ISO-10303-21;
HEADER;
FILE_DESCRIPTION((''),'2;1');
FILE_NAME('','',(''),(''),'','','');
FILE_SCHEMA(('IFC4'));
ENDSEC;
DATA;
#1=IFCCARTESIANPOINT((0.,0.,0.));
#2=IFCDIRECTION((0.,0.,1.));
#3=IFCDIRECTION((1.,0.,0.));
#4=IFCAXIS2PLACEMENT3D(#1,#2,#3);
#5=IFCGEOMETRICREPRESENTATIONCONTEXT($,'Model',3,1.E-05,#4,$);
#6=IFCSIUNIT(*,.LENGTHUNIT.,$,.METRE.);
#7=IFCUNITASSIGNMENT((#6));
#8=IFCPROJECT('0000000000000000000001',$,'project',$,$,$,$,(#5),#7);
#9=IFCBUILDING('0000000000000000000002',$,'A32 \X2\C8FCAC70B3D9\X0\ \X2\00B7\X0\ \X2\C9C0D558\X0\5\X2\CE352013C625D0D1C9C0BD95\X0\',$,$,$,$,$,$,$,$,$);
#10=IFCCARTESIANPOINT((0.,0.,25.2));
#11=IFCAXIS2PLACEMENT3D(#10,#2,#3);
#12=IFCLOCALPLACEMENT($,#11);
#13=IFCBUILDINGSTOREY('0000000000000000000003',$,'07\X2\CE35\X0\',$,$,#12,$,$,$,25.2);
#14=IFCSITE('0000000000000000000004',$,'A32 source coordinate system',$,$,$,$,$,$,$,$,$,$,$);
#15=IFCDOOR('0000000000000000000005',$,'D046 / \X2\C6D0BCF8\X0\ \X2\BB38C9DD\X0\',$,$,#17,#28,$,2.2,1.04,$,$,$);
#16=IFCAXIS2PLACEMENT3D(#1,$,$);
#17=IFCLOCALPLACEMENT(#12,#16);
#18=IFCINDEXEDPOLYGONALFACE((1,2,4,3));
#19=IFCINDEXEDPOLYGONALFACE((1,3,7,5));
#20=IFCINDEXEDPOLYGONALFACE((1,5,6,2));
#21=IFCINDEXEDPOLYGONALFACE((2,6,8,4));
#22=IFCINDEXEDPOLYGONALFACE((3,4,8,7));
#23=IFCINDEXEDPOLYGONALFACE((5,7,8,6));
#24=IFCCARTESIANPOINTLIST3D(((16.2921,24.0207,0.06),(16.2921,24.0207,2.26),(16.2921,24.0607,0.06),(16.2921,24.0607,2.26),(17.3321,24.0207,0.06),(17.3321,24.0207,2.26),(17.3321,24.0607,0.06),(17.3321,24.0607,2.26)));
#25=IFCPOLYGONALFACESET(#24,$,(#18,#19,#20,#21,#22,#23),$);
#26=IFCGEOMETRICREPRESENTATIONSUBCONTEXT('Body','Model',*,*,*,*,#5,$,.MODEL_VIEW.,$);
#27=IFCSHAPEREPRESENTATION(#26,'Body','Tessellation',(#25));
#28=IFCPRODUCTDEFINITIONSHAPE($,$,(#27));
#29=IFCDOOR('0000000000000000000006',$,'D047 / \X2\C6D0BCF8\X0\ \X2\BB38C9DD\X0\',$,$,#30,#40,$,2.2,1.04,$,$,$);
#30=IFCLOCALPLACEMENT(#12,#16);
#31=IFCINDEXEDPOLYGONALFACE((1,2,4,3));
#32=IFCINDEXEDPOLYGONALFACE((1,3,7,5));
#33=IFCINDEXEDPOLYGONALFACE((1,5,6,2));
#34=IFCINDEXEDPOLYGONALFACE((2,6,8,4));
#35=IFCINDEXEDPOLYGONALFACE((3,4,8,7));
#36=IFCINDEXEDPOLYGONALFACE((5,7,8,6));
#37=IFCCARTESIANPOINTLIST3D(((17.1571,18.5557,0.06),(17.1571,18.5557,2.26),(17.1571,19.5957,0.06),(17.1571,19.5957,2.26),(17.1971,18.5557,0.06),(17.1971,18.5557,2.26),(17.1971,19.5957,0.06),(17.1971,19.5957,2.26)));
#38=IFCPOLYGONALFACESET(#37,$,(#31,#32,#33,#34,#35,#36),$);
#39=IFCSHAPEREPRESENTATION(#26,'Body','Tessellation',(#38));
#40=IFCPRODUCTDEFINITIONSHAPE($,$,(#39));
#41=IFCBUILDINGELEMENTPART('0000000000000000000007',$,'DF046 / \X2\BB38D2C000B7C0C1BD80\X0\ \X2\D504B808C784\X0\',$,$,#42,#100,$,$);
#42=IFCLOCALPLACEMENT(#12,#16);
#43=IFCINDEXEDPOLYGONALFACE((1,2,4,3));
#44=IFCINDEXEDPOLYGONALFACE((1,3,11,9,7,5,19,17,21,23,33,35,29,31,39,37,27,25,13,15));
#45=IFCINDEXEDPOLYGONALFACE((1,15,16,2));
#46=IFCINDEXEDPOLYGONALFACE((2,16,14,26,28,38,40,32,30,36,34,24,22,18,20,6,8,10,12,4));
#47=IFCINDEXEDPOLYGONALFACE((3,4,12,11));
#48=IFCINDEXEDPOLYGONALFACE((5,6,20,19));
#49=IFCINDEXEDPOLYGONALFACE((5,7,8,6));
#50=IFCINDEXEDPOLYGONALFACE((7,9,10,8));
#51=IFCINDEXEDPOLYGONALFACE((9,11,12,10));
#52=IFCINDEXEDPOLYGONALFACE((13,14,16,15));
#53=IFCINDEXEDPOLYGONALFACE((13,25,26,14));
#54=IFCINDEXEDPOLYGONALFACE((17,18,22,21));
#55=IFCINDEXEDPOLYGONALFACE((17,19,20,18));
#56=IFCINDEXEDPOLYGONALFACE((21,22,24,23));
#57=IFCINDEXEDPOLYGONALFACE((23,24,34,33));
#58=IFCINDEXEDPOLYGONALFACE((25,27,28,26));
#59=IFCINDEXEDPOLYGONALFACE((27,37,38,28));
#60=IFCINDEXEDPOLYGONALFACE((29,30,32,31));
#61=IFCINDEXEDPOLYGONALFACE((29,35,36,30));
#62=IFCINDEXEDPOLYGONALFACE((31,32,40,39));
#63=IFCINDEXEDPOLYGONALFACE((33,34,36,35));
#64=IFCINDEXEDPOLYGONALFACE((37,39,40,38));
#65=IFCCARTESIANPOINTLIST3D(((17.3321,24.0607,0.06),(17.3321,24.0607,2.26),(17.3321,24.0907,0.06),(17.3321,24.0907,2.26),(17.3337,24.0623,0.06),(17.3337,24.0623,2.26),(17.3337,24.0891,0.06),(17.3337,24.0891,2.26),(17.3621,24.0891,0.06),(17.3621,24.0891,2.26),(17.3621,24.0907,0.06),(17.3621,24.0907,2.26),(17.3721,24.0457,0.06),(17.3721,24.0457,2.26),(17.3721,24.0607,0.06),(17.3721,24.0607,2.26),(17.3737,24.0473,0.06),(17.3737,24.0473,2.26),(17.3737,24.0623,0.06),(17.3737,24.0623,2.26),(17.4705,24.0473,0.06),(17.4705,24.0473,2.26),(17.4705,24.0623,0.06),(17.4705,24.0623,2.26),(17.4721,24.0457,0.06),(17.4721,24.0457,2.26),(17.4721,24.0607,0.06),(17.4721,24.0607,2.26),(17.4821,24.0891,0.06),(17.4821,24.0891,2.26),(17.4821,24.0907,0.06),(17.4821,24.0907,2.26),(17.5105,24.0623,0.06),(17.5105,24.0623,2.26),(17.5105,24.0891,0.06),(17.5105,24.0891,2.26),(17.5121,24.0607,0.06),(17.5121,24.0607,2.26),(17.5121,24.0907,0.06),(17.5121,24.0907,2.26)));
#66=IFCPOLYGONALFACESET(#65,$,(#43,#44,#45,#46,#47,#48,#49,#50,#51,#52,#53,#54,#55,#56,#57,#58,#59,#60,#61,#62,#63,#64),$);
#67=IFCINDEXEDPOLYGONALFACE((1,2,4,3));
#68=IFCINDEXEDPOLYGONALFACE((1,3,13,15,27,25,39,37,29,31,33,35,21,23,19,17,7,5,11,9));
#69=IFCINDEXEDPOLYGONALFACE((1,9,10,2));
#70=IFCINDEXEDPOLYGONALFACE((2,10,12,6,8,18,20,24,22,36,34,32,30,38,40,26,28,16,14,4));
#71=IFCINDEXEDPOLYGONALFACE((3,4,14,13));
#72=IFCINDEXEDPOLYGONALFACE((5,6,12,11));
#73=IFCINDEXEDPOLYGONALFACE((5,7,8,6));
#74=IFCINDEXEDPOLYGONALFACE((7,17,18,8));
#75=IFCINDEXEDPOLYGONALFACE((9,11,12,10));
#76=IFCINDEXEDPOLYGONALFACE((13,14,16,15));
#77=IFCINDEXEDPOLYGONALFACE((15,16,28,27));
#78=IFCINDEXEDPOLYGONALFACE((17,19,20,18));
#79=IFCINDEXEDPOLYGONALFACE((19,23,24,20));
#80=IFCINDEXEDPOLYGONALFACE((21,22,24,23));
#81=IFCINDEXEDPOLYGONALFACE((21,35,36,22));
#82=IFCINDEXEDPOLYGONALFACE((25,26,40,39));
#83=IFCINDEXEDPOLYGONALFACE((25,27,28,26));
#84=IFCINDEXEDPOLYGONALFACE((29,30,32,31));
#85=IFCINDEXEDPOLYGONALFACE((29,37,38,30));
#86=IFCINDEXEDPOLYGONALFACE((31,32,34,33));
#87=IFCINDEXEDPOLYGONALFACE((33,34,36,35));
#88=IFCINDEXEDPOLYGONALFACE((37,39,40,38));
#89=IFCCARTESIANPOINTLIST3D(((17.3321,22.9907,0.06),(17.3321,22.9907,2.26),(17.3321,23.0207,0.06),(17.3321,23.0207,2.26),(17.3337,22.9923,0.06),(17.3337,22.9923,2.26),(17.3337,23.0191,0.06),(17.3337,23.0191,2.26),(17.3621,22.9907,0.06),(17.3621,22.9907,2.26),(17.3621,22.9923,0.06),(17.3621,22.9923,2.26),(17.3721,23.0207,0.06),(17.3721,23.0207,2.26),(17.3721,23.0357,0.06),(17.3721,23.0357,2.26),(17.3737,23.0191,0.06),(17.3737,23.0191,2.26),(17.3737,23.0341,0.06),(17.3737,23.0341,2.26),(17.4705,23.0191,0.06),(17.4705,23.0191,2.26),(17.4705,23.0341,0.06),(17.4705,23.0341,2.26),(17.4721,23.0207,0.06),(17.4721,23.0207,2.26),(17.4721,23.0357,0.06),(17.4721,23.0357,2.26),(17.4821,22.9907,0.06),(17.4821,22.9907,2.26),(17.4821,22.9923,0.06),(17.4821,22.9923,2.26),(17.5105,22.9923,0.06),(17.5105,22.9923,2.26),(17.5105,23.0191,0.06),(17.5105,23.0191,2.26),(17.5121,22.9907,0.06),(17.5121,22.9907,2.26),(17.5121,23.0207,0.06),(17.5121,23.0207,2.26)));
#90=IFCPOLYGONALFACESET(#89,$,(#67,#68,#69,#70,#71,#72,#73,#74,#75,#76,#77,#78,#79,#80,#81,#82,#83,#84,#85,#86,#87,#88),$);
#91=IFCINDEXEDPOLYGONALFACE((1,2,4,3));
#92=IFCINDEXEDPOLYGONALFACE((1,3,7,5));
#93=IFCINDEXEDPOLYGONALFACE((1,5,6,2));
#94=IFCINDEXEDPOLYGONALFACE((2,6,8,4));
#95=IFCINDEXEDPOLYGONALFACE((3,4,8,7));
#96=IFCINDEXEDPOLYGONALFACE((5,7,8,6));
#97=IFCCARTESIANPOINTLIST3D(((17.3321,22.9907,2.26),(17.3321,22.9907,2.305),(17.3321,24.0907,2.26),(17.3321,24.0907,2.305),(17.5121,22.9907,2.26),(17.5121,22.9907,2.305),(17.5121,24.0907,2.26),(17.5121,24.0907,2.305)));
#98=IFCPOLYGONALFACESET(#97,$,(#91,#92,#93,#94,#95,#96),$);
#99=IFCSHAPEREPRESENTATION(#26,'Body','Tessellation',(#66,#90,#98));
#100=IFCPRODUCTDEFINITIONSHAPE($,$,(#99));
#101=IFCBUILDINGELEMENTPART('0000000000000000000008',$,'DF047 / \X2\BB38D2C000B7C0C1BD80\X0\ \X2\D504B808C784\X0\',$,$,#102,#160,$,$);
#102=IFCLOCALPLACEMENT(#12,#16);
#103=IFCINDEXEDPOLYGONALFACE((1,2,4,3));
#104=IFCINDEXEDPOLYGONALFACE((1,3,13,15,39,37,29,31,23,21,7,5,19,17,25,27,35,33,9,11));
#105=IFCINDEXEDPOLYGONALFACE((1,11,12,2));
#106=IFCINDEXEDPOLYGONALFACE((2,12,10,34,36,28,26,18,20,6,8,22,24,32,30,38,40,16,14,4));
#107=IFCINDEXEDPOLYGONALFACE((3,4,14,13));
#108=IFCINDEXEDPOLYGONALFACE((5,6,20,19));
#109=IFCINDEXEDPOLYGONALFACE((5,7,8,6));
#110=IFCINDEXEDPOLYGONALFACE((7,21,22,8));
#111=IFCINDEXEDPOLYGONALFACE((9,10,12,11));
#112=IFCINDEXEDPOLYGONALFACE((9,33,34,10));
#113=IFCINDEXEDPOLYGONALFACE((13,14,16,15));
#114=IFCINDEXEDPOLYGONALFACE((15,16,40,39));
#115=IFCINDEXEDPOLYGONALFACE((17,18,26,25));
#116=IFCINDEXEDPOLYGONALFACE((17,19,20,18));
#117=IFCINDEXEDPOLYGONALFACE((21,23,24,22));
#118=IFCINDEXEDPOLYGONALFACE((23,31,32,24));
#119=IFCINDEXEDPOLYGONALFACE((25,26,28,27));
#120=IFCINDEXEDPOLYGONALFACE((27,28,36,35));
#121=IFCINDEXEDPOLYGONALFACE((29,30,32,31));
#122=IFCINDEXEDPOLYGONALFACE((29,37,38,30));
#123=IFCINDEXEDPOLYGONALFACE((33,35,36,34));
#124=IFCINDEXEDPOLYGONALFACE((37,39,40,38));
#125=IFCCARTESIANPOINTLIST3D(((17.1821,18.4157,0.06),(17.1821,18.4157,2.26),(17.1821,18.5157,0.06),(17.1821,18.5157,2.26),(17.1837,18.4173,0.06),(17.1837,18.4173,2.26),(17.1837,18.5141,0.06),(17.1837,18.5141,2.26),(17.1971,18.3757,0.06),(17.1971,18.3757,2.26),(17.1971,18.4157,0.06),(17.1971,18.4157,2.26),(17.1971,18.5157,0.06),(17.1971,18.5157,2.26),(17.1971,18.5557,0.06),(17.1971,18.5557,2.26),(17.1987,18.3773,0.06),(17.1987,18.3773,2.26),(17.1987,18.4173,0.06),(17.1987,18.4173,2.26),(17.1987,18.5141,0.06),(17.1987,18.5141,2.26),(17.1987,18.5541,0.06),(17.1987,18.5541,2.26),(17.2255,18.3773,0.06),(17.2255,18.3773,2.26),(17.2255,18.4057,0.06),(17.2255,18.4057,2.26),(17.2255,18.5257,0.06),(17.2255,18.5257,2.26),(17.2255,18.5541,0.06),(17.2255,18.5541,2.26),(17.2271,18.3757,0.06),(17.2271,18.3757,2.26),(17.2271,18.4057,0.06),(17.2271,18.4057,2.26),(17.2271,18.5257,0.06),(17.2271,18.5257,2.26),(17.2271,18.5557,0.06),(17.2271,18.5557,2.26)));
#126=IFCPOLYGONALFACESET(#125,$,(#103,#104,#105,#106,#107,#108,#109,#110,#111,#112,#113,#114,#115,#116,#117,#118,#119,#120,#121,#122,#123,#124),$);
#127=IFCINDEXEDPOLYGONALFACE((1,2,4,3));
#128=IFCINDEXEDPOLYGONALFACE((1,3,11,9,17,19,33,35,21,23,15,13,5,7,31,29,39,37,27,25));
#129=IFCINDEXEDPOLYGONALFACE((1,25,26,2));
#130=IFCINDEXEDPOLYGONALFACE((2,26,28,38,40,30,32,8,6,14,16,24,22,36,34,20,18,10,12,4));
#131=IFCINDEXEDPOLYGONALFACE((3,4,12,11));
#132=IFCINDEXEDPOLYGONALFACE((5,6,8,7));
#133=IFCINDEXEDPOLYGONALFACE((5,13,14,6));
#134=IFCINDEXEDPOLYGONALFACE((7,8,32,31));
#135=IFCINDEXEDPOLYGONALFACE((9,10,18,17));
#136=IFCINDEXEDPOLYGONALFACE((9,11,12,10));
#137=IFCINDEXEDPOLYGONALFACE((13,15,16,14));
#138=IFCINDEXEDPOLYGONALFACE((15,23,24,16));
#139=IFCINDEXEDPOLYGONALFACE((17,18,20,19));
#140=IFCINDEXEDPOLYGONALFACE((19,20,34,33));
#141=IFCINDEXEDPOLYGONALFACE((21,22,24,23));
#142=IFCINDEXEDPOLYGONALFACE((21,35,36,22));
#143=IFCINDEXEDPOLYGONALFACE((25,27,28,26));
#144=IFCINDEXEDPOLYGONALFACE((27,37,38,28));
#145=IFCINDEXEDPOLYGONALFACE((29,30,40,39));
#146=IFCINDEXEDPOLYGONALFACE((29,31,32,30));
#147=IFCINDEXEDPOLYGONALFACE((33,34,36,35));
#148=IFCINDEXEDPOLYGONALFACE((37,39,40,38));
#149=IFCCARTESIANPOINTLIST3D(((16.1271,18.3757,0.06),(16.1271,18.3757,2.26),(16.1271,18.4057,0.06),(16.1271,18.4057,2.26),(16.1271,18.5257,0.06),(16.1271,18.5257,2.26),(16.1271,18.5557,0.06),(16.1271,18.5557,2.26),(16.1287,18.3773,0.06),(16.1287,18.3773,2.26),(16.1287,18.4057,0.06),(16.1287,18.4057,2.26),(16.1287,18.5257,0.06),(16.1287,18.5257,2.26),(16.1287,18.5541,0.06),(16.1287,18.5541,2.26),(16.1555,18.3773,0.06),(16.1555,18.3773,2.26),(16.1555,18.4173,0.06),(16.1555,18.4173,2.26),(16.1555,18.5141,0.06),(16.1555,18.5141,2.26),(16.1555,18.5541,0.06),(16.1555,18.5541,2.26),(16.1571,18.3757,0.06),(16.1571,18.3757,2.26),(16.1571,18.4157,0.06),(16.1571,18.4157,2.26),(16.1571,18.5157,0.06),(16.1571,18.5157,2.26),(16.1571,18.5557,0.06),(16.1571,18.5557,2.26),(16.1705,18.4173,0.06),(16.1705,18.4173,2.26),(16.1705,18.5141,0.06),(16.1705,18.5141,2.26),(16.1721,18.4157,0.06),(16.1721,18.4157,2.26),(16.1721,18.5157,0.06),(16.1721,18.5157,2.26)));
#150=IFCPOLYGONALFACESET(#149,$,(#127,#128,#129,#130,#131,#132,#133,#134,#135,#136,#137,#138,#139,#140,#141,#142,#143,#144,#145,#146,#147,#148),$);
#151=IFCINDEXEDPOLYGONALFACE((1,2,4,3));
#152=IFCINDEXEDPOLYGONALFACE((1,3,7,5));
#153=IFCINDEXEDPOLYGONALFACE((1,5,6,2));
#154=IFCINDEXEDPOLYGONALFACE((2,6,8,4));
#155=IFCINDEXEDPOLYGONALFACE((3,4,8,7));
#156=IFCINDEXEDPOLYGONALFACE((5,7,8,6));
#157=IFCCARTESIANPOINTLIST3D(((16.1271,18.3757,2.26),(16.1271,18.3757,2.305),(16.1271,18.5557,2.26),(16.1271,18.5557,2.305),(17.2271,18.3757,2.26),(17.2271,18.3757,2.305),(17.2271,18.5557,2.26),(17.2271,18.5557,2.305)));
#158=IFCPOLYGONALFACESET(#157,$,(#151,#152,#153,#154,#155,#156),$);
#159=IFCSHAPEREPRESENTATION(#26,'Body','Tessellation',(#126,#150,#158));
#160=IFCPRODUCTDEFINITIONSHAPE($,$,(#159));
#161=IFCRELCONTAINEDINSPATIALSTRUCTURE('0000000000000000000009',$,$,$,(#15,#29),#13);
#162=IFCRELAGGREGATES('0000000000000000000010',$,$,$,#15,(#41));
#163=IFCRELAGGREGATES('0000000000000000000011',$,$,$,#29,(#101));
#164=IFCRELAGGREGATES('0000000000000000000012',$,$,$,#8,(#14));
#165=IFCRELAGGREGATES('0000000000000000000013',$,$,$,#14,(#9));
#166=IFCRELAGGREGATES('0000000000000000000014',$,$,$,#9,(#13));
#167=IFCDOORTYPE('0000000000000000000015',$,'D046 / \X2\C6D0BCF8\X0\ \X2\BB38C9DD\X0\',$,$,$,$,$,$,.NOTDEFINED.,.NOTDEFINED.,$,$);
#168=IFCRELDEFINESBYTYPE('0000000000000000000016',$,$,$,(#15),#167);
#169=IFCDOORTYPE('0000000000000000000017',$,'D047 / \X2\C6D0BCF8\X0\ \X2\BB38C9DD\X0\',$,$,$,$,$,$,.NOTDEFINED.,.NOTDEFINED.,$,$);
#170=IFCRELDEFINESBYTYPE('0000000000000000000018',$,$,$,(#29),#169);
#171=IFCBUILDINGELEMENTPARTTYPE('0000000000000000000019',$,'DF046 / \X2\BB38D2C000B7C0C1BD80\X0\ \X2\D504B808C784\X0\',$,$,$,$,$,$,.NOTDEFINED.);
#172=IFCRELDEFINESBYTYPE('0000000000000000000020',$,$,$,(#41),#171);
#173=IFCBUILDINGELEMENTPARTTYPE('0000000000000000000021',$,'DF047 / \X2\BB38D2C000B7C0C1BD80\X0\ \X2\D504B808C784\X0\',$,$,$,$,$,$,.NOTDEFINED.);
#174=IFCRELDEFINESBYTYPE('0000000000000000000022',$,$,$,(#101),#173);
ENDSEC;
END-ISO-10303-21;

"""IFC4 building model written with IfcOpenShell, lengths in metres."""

from ifc_helpers import new_model, si_unit, frame, origin, origin_with_axes, place, context, subcontext, project, spatial, polyline, outline, extrude, source, transform, mapped, type_object, type_shapes, element, aggregate, save


model = new_model("IFC4")

# Units and contexts
model_context = context("Model", 3, precision=1e-05, world=origin_with_axes())
body_context = subcontext(model_context, "Body", "Model", "MODEL_VIEW")
ifc_project = project(units=[si_unit("LENGTHUNIT", "METRE")], contexts=[model_context])

# Site, building, storey
storey_placement = place(None, frame((0.0, 0.0, 25.2), z_axis=(0.0, 0.0, 1.0), x_axis=(1.0, 0.0, 0.0)))
site = spatial("IfcSite", under=ifc_project, Name="A32 source coordinate system")
building = spatial("IfcBuilding", under=site, Name="A32 주거동 · 지하5층–옥탑지붕")
storey = spatial("IfcBuildingStorey", under=building, at=storey_placement, Name="07층", Elevation=25.2)

# Doors
door_type_1 = type_object("IfcDoorType", Name="D046 / 원본 문짝", OperationType="NOTDEFINED", PredefinedType="NOTDEFINED")
shared_shape_1 = source(origin(), body_context, "Body", "SweptSolid", [
    extrude(outline(polyline([(17.3321, 24.0607), (17.3321, 24.0207), (16.2921, 24.0207), (16.2921, 24.0607), (17.3321, 24.0607)])), frame((0.0, 0.0, 0.06)), (0.0, 0.0, 1.0), 2.2),
])
type_shapes(door_type_1, [shared_shape_1])
door_1_placement = place(storey_placement, origin_with_axes())
door_1 = element("IfcDoor", 1, at=door_1_placement, inside=storey, type_object=door_type_1, Name="D046 / 원본 문짝", OverallHeight=2.2, OverallWidth=1.04, context=body_context, shape_type="MappedRepresentation", body=[
    mapped(shared_shape_1, transform((0.0, 0.0, 0.0), scale=1.0)),
])
door_type_2 = type_object("IfcDoorType", Name="D047 / 원본 문짝", OperationType="NOTDEFINED", PredefinedType="NOTDEFINED")
shared_shape_2 = source(origin(), body_context, "Body", "SweptSolid", [
    extrude(outline(polyline([(17.1971, 18.5557), (17.1571, 18.5557), (17.1571, 19.5957), (17.1971, 19.5957), (17.1971, 18.5557)])), frame((0.0, 0.0, 0.06)), (0.0, 0.0, 1.0), 2.2),
])
type_shapes(door_type_2, [shared_shape_2])
door_2_placement = place(storey_placement, origin_with_axes())
door_2 = element("IfcDoor", 2, at=door_2_placement, inside=storey, type_object=door_type_2, Name="D047 / 원본 문짝", OverallHeight=2.2, OverallWidth=1.04, context=body_context, shape_type="MappedRepresentation", body=[
    mapped(shared_shape_2, transform((0.0, 0.0, 0.0), scale=1.0)),
])

# Building element parts
building_element_part_type_1 = type_object("IfcBuildingElementPartType", Name="DF046 / 문틀·상부 프레임", PredefinedType="NOTDEFINED")
shared_shape_3 = source(origin(), body_context, "Body", "SweptSolid", [
    extrude(outline(polyline([(17.3337, 24.0891), (17.3337, 24.0623), (17.3737, 24.0623), (17.3737, 24.0473), (17.4705, 24.0473), (17.4705, 24.0623), (17.5105, 24.0623), (17.5105, 24.0891), (17.4821, 24.0891), (17.4821, 24.0907), (17.5121, 24.0907), (17.5121, 24.0607), (17.4721, 24.0607), (17.4721, 24.0457), (17.3721, 24.0457), (17.3721, 24.0607), (17.3321, 24.0607), (17.3321, 24.0907), (17.3621, 24.0907), (17.3621, 24.0891), (17.3337, 24.0891)])), frame((0.0, 0.0, 0.06)), (0.0, 0.0, 1.0), 2.2),
    extrude(outline(polyline([(17.3621, 22.9907), (17.3321, 22.9907), (17.3321, 23.0207), (17.3721, 23.0207), (17.3721, 23.0357), (17.4721, 23.0357), (17.4721, 23.0207), (17.5121, 23.0207), (17.5121, 22.9907), (17.4821, 22.9907), (17.4821, 22.9923), (17.5105, 22.9923), (17.5105, 23.0191), (17.4705, 23.0191), (17.4705, 23.0341), (17.3737, 23.0341), (17.3737, 23.0191), (17.3337, 23.0191), (17.3337, 22.9923), (17.3621, 22.9923), (17.3621, 22.9907)])), frame((0.0, 0.0, 0.06)), (0.0, 0.0, 1.0), 2.2),
    extrude(outline(polyline([(17.3321, 22.9907), (17.3321, 24.0907), (17.5121, 24.0907), (17.5121, 22.9907), (17.3321, 22.9907)])), frame((0.0, 0.0, 2.26)), (0.0, 0.0, 1.0), 0.045),
])
type_shapes(building_element_part_type_1, [shared_shape_3])
building_element_part_1_placement = place(door_1_placement, origin_with_axes())
building_element_part_1 = element("IfcBuildingElementPart", 3, at=building_element_part_1_placement, type_object=building_element_part_type_1, Name="DF046 / 문틀·상부 프레임", context=body_context, shape_type="MappedRepresentation", body=[
    mapped(shared_shape_3, transform((0.0, 0.0, 0.0), scale=1.0)),
])
aggregate(door_1, [building_element_part_1])
building_element_part_type_2 = type_object("IfcBuildingElementPartType", Name="DF047 / 문틀·상부 프레임", PredefinedType="NOTDEFINED")
shared_shape_4 = source(origin(), body_context, "Body", "SweptSolid", [
    extrude(outline(polyline([(17.2255, 18.5541), (17.1987, 18.5541), (17.1987, 18.5141), (17.1837, 18.5141), (17.1837, 18.4173), (17.1987, 18.4173), (17.1987, 18.3773), (17.2255, 18.3773), (17.2255, 18.4057), (17.2271, 18.4057), (17.2271, 18.3757), (17.1971, 18.3757), (17.1971, 18.4157), (17.1821, 18.4157), (17.1821, 18.5157), (17.1971, 18.5157), (17.1971, 18.5557), (17.2271, 18.5557), (17.2271, 18.5257), (17.2255, 18.5257), (17.2255, 18.5541)])), frame((0.0, 0.0, 0.06)), (0.0, 0.0, 1.0), 2.2),
    extrude(outline(polyline([(16.1271, 18.5257), (16.1271, 18.5557), (16.1571, 18.5557), (16.1571, 18.5157), (16.1721, 18.5157), (16.1721, 18.4157), (16.1571, 18.4157), (16.1571, 18.3757), (16.1271, 18.3757), (16.1271, 18.4057), (16.1287, 18.4057), (16.1287, 18.3773), (16.1555, 18.3773), (16.1555, 18.4173), (16.1705, 18.4173), (16.1705, 18.5141), (16.1555, 18.5141), (16.1555, 18.5541), (16.1287, 18.5541), (16.1287, 18.5257), (16.1271, 18.5257)])), frame((0.0, 0.0, 0.06)), (0.0, 0.0, 1.0), 2.2),
    extrude(outline(polyline([(16.1271, 18.3757), (16.1271, 18.5557), (17.2271, 18.5557), (17.2271, 18.3757), (16.1271, 18.3757)])), frame((0.0, 0.0, 2.26)), (0.0, 0.0, 1.0), 0.045),
])
type_shapes(building_element_part_type_2, [shared_shape_4])
building_element_part_2_placement = place(door_2_placement, origin_with_axes())
building_element_part_2 = element("IfcBuildingElementPart", 4, at=building_element_part_2_placement, type_object=building_element_part_type_2, Name="DF047 / 문틀·상부 프레임", context=body_context, shape_type="MappedRepresentation", body=[
    mapped(shared_shape_4, transform((0.0, 0.0, 0.0), scale=1.0)),
])
aggregate(door_2, [building_element_part_2])

save(model, "model.ifc")
